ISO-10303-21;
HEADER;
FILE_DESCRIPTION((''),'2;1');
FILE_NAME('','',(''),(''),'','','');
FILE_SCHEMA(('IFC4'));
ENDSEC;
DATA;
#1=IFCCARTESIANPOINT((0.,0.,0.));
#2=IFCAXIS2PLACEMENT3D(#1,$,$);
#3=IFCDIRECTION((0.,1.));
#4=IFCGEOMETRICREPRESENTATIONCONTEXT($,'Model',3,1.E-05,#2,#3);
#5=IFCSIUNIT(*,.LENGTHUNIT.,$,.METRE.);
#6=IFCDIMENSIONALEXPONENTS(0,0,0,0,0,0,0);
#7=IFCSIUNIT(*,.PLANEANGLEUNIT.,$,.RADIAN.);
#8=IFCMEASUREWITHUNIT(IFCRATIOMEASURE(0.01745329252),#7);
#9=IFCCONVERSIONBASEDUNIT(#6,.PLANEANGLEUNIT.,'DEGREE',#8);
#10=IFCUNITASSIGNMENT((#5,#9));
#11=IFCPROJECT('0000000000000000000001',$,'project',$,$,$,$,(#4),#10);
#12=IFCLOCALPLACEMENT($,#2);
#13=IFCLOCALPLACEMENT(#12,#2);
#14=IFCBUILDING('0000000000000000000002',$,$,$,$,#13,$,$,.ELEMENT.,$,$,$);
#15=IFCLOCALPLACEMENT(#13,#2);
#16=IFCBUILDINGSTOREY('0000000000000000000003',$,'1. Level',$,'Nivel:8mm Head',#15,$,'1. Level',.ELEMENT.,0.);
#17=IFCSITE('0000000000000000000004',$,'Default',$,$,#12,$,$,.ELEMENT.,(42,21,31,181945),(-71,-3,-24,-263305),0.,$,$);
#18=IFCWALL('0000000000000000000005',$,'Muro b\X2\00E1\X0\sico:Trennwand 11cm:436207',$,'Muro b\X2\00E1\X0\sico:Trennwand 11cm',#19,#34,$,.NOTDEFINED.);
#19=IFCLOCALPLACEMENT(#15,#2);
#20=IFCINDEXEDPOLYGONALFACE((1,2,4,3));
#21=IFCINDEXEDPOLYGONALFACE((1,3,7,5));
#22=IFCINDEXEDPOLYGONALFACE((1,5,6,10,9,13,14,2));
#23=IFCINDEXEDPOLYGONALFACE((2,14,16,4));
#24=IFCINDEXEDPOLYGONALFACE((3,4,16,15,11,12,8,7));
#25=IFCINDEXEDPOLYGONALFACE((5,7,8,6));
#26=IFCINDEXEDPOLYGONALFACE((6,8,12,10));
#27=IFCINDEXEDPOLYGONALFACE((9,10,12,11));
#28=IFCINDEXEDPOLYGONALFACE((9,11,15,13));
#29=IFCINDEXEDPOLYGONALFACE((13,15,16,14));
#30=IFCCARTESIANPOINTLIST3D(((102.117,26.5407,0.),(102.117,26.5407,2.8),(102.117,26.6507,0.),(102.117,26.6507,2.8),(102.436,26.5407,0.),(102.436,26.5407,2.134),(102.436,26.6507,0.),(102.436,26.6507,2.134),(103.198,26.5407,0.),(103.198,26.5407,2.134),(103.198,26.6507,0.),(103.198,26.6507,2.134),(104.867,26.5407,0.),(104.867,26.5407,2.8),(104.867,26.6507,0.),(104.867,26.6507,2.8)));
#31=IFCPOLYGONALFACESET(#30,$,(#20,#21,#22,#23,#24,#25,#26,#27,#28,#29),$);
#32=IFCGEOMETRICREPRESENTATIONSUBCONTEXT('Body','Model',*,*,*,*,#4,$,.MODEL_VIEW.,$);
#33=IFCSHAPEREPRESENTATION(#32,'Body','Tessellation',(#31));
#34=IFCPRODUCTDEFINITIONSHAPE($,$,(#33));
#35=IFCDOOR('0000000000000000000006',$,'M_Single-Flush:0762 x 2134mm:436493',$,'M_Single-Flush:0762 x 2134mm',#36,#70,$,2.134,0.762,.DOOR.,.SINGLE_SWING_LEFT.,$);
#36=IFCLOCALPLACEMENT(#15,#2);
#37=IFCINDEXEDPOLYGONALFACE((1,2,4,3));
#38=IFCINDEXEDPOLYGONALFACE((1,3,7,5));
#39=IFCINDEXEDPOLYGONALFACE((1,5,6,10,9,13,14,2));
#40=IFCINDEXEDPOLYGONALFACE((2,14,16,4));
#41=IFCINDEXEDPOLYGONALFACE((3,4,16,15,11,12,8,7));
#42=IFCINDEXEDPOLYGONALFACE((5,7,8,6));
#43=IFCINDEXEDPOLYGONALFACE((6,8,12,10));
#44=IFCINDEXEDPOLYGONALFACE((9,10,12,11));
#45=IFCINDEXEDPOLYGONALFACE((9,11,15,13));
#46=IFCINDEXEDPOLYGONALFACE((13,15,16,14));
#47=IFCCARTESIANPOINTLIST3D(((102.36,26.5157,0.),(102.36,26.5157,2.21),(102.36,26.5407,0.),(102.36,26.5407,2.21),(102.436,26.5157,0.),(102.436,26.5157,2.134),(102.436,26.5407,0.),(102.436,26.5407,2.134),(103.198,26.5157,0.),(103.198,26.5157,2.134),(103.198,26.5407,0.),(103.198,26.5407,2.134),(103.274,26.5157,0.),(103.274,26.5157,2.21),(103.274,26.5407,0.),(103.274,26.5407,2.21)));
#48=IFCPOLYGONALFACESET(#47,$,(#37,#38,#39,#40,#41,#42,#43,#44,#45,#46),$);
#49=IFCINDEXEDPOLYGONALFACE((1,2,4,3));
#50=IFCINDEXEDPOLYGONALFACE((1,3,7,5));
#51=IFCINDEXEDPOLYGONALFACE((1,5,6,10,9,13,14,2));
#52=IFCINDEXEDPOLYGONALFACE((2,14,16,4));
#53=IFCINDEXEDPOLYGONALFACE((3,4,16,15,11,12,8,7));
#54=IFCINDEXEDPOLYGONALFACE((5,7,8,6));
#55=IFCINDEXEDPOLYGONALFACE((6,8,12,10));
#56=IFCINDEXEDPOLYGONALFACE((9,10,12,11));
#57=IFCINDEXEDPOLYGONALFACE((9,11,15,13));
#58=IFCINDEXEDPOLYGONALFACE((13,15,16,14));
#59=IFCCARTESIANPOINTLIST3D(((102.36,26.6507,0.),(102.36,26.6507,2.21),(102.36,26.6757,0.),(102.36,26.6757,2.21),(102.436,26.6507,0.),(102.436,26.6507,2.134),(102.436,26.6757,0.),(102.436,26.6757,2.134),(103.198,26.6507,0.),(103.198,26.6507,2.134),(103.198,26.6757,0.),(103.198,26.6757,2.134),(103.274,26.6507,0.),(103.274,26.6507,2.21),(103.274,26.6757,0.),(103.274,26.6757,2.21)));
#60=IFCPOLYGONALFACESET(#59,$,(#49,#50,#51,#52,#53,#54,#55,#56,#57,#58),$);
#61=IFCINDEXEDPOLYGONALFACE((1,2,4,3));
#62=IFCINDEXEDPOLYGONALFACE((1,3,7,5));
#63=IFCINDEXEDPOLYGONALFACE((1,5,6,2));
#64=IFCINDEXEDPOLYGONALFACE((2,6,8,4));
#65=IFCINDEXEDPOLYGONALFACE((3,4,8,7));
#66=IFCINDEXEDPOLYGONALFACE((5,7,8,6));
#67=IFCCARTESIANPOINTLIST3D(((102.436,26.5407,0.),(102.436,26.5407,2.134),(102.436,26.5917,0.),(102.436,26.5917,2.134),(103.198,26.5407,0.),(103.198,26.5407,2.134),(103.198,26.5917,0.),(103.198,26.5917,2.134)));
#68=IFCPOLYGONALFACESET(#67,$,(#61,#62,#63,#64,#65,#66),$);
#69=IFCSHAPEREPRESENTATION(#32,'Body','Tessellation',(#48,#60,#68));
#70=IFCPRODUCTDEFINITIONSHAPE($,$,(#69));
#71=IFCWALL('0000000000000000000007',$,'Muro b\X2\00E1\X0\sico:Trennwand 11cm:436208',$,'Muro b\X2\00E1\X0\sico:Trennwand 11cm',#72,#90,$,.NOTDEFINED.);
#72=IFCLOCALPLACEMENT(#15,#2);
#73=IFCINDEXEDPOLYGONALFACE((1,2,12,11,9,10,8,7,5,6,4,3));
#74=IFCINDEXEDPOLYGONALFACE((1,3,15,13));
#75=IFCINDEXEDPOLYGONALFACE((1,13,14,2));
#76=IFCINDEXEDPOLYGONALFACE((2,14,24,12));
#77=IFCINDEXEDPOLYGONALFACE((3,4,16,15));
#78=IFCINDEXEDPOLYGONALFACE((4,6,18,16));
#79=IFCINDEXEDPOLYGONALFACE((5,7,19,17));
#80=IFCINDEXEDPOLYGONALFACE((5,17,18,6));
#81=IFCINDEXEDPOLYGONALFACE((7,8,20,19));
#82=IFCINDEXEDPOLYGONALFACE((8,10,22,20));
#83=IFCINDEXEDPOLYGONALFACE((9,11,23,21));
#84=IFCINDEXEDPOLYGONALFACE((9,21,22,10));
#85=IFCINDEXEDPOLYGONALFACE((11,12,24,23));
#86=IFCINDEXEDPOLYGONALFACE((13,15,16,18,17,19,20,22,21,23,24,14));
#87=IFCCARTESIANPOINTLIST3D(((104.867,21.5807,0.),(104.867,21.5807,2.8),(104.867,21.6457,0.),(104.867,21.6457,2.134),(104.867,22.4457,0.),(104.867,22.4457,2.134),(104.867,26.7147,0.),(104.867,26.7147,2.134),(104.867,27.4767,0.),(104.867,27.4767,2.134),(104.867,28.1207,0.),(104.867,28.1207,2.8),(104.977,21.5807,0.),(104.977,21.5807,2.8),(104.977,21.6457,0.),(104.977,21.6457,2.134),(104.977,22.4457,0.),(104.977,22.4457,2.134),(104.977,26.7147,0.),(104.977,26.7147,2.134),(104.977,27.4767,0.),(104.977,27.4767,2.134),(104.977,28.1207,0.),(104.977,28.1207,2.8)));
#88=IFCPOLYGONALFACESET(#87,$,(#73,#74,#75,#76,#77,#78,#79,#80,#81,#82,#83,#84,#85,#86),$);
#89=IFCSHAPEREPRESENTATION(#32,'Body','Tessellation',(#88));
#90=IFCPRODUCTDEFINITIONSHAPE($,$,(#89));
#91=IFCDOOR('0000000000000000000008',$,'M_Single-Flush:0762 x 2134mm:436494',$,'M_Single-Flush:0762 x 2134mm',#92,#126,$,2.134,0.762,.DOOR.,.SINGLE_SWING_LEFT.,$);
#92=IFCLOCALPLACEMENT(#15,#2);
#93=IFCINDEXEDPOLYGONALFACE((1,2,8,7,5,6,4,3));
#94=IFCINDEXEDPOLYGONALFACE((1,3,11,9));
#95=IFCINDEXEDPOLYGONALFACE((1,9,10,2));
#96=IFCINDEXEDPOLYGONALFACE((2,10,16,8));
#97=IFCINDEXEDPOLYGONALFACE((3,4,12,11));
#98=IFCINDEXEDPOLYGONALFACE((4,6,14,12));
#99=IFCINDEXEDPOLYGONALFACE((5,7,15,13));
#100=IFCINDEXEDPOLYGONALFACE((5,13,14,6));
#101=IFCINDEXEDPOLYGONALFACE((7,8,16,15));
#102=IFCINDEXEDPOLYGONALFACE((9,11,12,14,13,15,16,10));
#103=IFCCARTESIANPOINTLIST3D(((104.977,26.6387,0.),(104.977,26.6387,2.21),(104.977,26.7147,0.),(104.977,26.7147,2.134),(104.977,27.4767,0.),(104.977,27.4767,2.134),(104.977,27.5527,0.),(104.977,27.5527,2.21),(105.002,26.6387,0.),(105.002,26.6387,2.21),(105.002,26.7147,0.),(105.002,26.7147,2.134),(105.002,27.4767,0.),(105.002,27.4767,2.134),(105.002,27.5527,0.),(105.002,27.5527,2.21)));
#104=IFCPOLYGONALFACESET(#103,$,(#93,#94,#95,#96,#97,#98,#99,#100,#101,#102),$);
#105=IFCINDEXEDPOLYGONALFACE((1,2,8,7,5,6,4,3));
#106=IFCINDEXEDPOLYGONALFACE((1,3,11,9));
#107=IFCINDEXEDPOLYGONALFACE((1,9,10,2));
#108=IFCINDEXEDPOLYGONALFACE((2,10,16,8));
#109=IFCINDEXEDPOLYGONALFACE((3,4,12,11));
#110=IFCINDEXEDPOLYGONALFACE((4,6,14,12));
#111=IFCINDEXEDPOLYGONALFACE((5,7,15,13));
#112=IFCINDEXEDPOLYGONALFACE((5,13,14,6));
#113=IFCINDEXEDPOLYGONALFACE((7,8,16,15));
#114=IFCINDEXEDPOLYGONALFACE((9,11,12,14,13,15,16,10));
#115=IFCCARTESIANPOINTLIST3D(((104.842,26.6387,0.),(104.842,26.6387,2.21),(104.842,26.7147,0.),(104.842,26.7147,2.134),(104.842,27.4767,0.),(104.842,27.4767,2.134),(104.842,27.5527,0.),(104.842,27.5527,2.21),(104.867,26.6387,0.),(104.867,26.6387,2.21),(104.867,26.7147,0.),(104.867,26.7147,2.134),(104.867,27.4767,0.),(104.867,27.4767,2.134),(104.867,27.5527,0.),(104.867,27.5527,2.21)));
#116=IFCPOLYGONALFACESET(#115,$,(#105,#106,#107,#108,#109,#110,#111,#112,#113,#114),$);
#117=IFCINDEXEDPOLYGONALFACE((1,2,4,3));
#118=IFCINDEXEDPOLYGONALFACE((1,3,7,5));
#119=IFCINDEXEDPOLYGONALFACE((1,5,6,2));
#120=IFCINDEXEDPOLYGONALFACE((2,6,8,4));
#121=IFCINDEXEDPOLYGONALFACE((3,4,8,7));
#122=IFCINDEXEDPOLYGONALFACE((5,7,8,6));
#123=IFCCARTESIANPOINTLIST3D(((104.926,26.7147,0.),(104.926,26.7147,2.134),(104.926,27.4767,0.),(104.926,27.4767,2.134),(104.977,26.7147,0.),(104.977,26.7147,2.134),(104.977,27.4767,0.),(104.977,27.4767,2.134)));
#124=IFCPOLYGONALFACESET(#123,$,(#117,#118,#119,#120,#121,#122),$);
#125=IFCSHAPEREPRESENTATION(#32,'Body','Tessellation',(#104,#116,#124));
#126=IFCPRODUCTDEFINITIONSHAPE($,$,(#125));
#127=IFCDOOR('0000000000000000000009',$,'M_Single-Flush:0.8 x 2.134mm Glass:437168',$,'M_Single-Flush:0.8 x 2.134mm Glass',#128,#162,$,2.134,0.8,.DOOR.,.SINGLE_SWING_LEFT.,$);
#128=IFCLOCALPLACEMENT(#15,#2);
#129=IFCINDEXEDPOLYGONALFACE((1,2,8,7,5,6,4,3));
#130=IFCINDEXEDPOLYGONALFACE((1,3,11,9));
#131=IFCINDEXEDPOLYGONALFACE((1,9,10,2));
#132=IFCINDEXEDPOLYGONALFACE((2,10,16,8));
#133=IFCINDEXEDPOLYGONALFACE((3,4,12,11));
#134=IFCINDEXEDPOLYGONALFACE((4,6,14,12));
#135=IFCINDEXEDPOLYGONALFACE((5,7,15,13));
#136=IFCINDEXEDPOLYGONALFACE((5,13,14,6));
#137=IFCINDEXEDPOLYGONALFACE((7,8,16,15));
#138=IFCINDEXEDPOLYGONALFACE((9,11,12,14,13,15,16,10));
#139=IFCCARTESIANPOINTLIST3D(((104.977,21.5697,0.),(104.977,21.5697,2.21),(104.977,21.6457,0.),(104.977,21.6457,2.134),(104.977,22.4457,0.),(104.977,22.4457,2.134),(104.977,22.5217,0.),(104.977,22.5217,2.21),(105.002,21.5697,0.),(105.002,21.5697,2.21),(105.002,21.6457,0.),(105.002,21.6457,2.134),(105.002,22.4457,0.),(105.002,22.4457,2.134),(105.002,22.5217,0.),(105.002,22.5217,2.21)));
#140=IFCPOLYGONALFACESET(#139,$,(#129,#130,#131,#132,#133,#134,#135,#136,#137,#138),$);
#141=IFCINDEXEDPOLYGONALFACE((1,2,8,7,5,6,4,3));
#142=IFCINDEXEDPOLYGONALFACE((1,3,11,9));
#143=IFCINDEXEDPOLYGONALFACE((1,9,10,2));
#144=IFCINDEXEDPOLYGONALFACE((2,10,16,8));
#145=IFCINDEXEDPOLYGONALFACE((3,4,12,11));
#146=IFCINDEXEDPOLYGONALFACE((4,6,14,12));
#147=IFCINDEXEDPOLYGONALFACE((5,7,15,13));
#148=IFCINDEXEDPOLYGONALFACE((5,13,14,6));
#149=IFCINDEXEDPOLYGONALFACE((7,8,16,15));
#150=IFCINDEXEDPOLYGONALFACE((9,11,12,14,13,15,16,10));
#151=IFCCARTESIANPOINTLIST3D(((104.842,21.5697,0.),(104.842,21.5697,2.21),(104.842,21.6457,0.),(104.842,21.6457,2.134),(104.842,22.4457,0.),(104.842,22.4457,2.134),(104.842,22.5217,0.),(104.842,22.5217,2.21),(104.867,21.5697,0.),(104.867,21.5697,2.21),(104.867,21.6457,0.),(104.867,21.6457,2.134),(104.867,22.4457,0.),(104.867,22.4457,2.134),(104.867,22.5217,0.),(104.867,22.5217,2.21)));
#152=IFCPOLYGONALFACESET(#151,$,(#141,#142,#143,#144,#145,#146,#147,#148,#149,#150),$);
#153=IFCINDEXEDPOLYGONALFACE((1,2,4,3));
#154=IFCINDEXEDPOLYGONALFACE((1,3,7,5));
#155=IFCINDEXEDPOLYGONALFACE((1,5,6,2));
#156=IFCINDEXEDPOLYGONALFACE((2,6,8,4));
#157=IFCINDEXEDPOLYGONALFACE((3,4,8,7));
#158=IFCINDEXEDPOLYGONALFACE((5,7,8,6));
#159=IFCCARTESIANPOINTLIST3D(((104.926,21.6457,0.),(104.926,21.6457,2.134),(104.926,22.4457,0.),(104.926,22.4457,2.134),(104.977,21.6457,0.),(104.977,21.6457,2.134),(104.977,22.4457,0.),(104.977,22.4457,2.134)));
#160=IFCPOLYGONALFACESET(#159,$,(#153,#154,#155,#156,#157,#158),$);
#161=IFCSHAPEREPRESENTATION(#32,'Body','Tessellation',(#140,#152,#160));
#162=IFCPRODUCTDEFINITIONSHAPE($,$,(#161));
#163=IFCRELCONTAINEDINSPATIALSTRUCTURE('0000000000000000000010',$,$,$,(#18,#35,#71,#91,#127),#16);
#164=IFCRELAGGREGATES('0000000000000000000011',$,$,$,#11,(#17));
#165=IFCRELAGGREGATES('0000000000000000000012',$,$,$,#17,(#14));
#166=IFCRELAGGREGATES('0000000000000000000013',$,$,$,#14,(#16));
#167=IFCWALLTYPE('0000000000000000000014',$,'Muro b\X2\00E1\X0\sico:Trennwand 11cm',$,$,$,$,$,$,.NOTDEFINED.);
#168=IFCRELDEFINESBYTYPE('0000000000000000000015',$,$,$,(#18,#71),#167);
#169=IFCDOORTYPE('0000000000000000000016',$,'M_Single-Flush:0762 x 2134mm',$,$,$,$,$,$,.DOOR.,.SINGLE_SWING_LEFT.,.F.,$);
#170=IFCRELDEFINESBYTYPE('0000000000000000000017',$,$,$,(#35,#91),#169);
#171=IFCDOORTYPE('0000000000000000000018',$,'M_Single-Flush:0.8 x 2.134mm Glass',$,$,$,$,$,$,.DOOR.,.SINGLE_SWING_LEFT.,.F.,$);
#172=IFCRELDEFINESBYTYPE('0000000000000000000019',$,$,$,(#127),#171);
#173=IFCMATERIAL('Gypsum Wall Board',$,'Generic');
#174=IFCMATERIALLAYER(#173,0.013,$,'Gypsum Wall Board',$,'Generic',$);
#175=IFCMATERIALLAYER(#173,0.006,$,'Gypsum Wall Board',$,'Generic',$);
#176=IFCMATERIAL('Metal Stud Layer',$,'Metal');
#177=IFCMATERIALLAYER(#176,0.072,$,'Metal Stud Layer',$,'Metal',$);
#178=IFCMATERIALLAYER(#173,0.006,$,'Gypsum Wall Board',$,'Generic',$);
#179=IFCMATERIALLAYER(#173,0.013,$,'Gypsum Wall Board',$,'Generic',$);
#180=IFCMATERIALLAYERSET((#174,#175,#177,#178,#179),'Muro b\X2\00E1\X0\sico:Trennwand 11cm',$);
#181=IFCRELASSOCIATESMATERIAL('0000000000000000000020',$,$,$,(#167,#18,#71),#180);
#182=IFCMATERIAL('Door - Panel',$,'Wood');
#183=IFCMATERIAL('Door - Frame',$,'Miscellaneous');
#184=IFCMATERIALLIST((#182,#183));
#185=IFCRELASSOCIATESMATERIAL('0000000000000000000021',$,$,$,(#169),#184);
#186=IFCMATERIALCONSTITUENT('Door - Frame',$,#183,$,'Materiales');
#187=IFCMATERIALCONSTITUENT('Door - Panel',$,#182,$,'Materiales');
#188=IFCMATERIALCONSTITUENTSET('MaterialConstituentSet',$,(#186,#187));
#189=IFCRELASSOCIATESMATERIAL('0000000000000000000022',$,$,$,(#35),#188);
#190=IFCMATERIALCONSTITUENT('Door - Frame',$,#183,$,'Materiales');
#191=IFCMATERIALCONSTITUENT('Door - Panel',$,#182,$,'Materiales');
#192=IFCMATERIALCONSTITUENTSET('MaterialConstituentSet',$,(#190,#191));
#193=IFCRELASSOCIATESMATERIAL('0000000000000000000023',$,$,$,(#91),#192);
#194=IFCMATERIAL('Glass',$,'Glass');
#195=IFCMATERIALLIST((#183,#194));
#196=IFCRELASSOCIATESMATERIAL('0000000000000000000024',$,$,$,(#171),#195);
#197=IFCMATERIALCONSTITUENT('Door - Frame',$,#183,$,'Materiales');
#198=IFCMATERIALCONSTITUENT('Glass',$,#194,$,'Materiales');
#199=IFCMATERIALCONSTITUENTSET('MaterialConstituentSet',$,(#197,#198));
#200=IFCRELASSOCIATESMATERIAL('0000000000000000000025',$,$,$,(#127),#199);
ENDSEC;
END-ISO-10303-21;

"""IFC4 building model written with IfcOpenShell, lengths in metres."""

from ifc_helpers import new_model, entity, si_unit, converted_unit, direction, frame, frame_2d, origin, origin_2d_with_axis, place, context, subcontext, project, spatial, polyline, rectangle, outline, extrude, source, transform, mapped, material, material_list, layer, layer_set, layer_usage, constituent, constituent_set, type_object, type_shapes, element, fill, save


model = new_model("IFC4")

# Units and contexts
model_context = context("Model", 3, precision=1e-05, world=origin(), true_north=direction((0.0, 1.0)))
body_context = subcontext(model_context, "Body", "Model", "MODEL_VIEW")
ifc_project = project(units=[si_unit("LENGTHUNIT", "METRE"), converted_unit("PLANEANGLEUNIT", "DEGREE", entity("IfcRatioMeasure", 0.01745329252), si_unit("PLANEANGLEUNIT", "RADIAN"), dimensions=[0, 0, 0, 0, 0, 0, 0])], contexts=[model_context])

# Site, building, storey
site_placement = place(None, origin())
site = spatial("IfcSite", under=ifc_project, at=site_placement, Name="Default", CompositionType="ELEMENT", RefLatitude=(42, 21, 31, 181945), RefLongitude=(-71, -3, -24, -263305), RefElevation=0.0)
building_placement = place(site_placement, origin())
building = spatial("IfcBuilding", under=site, at=building_placement, CompositionType="ELEMENT")
storey_placement = place(building_placement, origin())
storey = spatial("IfcBuildingStorey", under=building, at=storey_placement, Name="1. Level", ObjectType="Nivel:8mm Head", LongName="1. Level", CompositionType="ELEMENT", Elevation=0.0)

# Wall, opening, door
ifc_material_1 = material(Name="Gypsum Wall Board", Category="Generic")
ifc_layer_1 = layer(ifc_material_1, 0.013, Name="Gypsum Wall Board", Category="Generic")
ifc_layer_2 = layer(ifc_material_1, 0.006, Name="Gypsum Wall Board", Category="Generic")
ifc_material_2 = material(Name="Metal Stud Layer", Category="Metal")
ifc_layer_3 = layer(ifc_material_2, 0.072, Name="Metal Stud Layer", Category="Metal")
ifc_layer_4 = layer(ifc_material_1, 0.006, Name="Gypsum Wall Board", Category="Generic")
ifc_layer_5 = layer(ifc_material_1, 0.013, Name="Gypsum Wall Board", Category="Generic")
ifc_layer_set_1 = layer_set([ifc_layer_1, ifc_layer_2, ifc_layer_3, ifc_layer_4, ifc_layer_5], Name="Muro básico:Trennwand 11cm")
ifc_layer_usage_1 = layer_usage(ifc_layer_set_1, "AXIS2", "NEGATIVE", 0.055)
wall_type_1 = type_object("IfcWallType", Name="Muro básico:Trennwand 11cm", PredefinedType="NOTDEFINED", material=ifc_layer_set_1)
wall_1_placement = place(storey_placement, frame((102.117, 26.5957, 0.0)))
wall_1 = element("IfcWall", 1, at=wall_1_placement, inside=storey, type_object=wall_type_1, material=ifc_layer_usage_1, Name="Muro básico:Trennwand 11cm:436207", ObjectType="Muro básico:Trennwand 11cm", PredefinedType="NOTDEFINED", context=body_context, shape_type="SweptSolid", body=[
    extrude(rectangle(XDim=2.75, YDim=0.11, at=frame_2d((1.375, 0.0), x_axis=(-1.0, 0.0))), origin(), (0.0, 0.0, 1.0), 2.8),
])
opening_1_placement = place(wall_1_placement, frame((1.081, 0.055, 0.0)))
opening_1 = element("IfcOpeningElement", 2, at=opening_1_placement, cuts=wall_1, ObjectType="Opening", PredefinedType="OPENING", context=body_context, shape_type="SweptSolid", body=[
    extrude(rectangle(XDim=0.762, YDim=2.134, at=frame_2d((1.067, 0.381), x_axis=(0.0, -1.0))), frame((0.0, 0.0, 0.0), z_axis=(0.0, -1.0, 0.0), x_axis=(0.0, 0.0, 1.0)), (0.0, 0.0, 1.0), 0.11),
])
ifc_material_3 = material(Name="Door - Frame", Category="Miscellaneous")
ifc_constituent_1 = constituent(ifc_material_3, Name="Door - Frame", Category="Materiales")
ifc_material_4 = material(Name="Door - Panel", Category="Wood")
ifc_constituent_2 = constituent(ifc_material_4, Name="Door - Panel", Category="Materiales")
ifc_constituent_set_1 = constituent_set(constituents=[ifc_constituent_1, ifc_constituent_2], Name="MaterialConstituentSet")
ifc_material_list_1 = material_list([ifc_material_4, ifc_material_3])
door_type_1 = type_object("IfcDoorType", Name="M_Single-Flush:0762 x 2134mm", OperationType="SINGLE_SWING_LEFT", ParameterTakesPrecedence=False, PredefinedType="DOOR", material=ifc_material_list_1)
shared_shape_1 = source(origin(), body_context, "Body", "SweptSolid", [
    extrude(outline(polyline([(-0.457, -1.124), (0.457, -1.124), (0.457, 1.086), (0.381, 1.086), (0.381, -1.048), (-0.381, -1.048), (-0.381, 1.086), (-0.457, 1.086), (-0.457, -1.124)])), frame((0.381, 0.135, 1.086), z_axis=(0.0, -1.0, 0.0), x_axis=(-1.0, 0.0, 0.0)), (0.0, 0.0, 1.0), 0.025),
    extrude(outline(polyline([(-1.124, -0.457), (1.086, -0.457), (1.086, -0.381), (-1.048, -0.381), (-1.048, 0.381), (1.086, 0.381), (1.086, 0.457), (-1.124, 0.457), (-1.124, -0.457)])), frame((0.381, 0.0, 1.086), z_axis=(0.0, -1.0, 0.0), x_axis=(0.0, 0.0, -1.0)), (0.0, 0.0, 1.0), 0.025),
    extrude(rectangle(XDim=0.762, YDim=0.051, at=origin_2d_with_axis()), frame((0.381, 0.0845, 0.0)), (0.0, 0.0, 1.0), 2.134),
])
type_shapes(door_type_1, [shared_shape_1])
door_1_placement = place(opening_1_placement, frame((0.0, 0.0, 0.0), z_axis=(0.0, 0.0, 1.0), x_axis=(-1.0, 0.0, 0.0)))
door_1 = element("IfcDoor", 3, at=door_1_placement, inside=storey, type_object=door_type_1, material=ifc_constituent_set_1, Name="M_Single-Flush:0762 x 2134mm:436493", ObjectType="M_Single-Flush:0762 x 2134mm", OperationType="SINGLE_SWING_LEFT", OverallHeight=2.134, OverallWidth=0.762, PredefinedType="DOOR", context=body_context, shape_type="MappedRepresentation", body=[
    mapped(shared_shape_1, transform((0.0, 0.0, 0.0), scale=1.0)),
])
fill(opening_1, door_1)

# Wall, openings, doors
ifc_layer_usage_2 = layer_usage(ifc_layer_set_1, "AXIS2", "NEGATIVE", 0.055)
wall_2_placement = place(storey_placement, frame((104.922, 21.5807, 0.0), z_axis=(0.0, 0.0, 1.0), x_axis=(0.0, 1.0, 0.0)))
wall_2 = element("IfcWall", 4, at=wall_2_placement, inside=storey, type_object=wall_type_1, material=ifc_layer_usage_2, Name="Muro básico:Trennwand 11cm:436208", ObjectType="Muro básico:Trennwand 11cm", PredefinedType="NOTDEFINED", context=body_context, shape_type="SweptSolid", body=[
    extrude(rectangle(XDim=6.54, YDim=0.11, at=frame_2d((3.27, 0.0), x_axis=(-1.0, 0.0))), origin(), (0.0, 0.0, 1.0), 2.8),
])
opening_2_placement = place(wall_2_placement, frame((5.896, 0.055, 0.0)))
opening_2 = element("IfcOpeningElement", 5, at=opening_2_placement, cuts=wall_2, ObjectType="Opening", PredefinedType="OPENING", context=body_context, shape_type="SweptSolid", body=[
    extrude(rectangle(XDim=0.762, YDim=2.134, at=frame_2d((1.067, 0.381), x_axis=(0.0, -1.0))), frame((0.0, 0.0, 0.0), z_axis=(0.0, -1.0, 0.0), x_axis=(0.0, 0.0, 1.0)), (0.0, 0.0, 1.0), 0.11),
])
opening_3_placement = place(wall_2_placement, frame((0.865, 0.055, 0.0)))
opening_3 = element("IfcOpeningElement", 6, at=opening_3_placement, cuts=wall_2, ObjectType="Opening", PredefinedType="OPENING", context=body_context, shape_type="SweptSolid", body=[
    extrude(rectangle(XDim=0.8, YDim=2.134, at=frame_2d((1.067, 0.4), x_axis=(0.0, -1.0))), frame((0.0, 0.0, 0.0), z_axis=(0.0, -1.0, 0.0), x_axis=(0.0, 0.0, 1.0)), (0.0, 0.0, 1.0), 0.11),
])
ifc_constituent_3 = constituent(ifc_material_3, Name="Door - Frame", Category="Materiales")
ifc_constituent_4 = constituent(ifc_material_4, Name="Door - Panel", Category="Materiales")
ifc_constituent_set_2 = constituent_set(constituents=[ifc_constituent_3, ifc_constituent_4], Name="MaterialConstituentSet")
door_2_placement = place(opening_2_placement, frame((0.0, 0.0, 0.0), z_axis=(0.0, 0.0, 1.0), x_axis=(-1.0, 0.0, 0.0)))
door_2 = element("IfcDoor", 7, at=door_2_placement, inside=storey, type_object=door_type_1, material=ifc_constituent_set_2, Name="M_Single-Flush:0762 x 2134mm:436494", ObjectType="M_Single-Flush:0762 x 2134mm", OperationType="SINGLE_SWING_LEFT", OverallHeight=2.134, OverallWidth=0.762, PredefinedType="DOOR", context=body_context, shape_type="MappedRepresentation", body=[
    mapped(shared_shape_1, transform((0.0, 0.0, 0.0), scale=1.0)),
])
fill(opening_2, door_2)
ifc_constituent_5 = constituent(ifc_material_3, Name="Door - Frame", Category="Materiales")
ifc_material_5 = material(Name="Glass", Category="Glass")
ifc_constituent_6 = constituent(ifc_material_5, Name="Glass", Category="Materiales")
ifc_constituent_set_3 = constituent_set(constituents=[ifc_constituent_5, ifc_constituent_6], Name="MaterialConstituentSet")
ifc_material_list_2 = material_list([ifc_material_3, ifc_material_5])
door_type_2 = type_object("IfcDoorType", Name="M_Single-Flush:0.8 x 2.134mm Glass", OperationType="SINGLE_SWING_LEFT", ParameterTakesPrecedence=False, PredefinedType="DOOR", material=ifc_material_list_2)
shared_shape_2 = source(origin(), body_context, "Body", "SweptSolid", [
    extrude(outline(polyline([(-0.476, -1.124), (0.476, -1.124), (0.476, 1.086), (0.4, 1.086), (0.4, -1.048), (-0.4, -1.048), (-0.4, 1.086), (-0.476, 1.086), (-0.476, -1.124)])), frame((0.4, 0.135, 1.086), z_axis=(0.0, -1.0, 0.0), x_axis=(-1.0, 0.0, 0.0)), (0.0, 0.0, 1.0), 0.025),
    extrude(outline(polyline([(-1.124, -0.476), (1.086, -0.476), (1.086, -0.4), (-1.048, -0.4), (-1.048, 0.4), (1.086, 0.4), (1.086, 0.476), (-1.124, 0.476), (-1.124, -0.476)])), frame((0.4, 0.0, 1.086), z_axis=(0.0, -1.0, 0.0), x_axis=(0.0, 0.0, -1.0)), (0.0, 0.0, 1.0), 0.025),
    extrude(rectangle(XDim=0.8, YDim=0.051, at=origin_2d_with_axis()), frame((0.4, 0.0845, 0.0)), (0.0, 0.0, 1.0), 2.134),
])
type_shapes(door_type_2, [shared_shape_2])
door_3_placement = place(opening_3_placement, frame((0.0, 0.0, 0.0), z_axis=(0.0, 0.0, 1.0), x_axis=(-1.0, 0.0, 0.0)))
door_3 = element("IfcDoor", 8, at=door_3_placement, inside=storey, type_object=door_type_2, material=ifc_constituent_set_3, Name="M_Single-Flush:0.8 x 2.134mm Glass:437168", ObjectType="M_Single-Flush:0.8 x 2.134mm Glass", OperationType="SINGLE_SWING_LEFT", OverallHeight=2.134, OverallWidth=0.8, PredefinedType="DOOR", context=body_context, shape_type="MappedRepresentation", body=[
    mapped(shared_shape_2, transform((0.0, 0.0, 0.0), scale=1.0)),
])
fill(opening_3, door_3)

save(model, "model.ifc")
